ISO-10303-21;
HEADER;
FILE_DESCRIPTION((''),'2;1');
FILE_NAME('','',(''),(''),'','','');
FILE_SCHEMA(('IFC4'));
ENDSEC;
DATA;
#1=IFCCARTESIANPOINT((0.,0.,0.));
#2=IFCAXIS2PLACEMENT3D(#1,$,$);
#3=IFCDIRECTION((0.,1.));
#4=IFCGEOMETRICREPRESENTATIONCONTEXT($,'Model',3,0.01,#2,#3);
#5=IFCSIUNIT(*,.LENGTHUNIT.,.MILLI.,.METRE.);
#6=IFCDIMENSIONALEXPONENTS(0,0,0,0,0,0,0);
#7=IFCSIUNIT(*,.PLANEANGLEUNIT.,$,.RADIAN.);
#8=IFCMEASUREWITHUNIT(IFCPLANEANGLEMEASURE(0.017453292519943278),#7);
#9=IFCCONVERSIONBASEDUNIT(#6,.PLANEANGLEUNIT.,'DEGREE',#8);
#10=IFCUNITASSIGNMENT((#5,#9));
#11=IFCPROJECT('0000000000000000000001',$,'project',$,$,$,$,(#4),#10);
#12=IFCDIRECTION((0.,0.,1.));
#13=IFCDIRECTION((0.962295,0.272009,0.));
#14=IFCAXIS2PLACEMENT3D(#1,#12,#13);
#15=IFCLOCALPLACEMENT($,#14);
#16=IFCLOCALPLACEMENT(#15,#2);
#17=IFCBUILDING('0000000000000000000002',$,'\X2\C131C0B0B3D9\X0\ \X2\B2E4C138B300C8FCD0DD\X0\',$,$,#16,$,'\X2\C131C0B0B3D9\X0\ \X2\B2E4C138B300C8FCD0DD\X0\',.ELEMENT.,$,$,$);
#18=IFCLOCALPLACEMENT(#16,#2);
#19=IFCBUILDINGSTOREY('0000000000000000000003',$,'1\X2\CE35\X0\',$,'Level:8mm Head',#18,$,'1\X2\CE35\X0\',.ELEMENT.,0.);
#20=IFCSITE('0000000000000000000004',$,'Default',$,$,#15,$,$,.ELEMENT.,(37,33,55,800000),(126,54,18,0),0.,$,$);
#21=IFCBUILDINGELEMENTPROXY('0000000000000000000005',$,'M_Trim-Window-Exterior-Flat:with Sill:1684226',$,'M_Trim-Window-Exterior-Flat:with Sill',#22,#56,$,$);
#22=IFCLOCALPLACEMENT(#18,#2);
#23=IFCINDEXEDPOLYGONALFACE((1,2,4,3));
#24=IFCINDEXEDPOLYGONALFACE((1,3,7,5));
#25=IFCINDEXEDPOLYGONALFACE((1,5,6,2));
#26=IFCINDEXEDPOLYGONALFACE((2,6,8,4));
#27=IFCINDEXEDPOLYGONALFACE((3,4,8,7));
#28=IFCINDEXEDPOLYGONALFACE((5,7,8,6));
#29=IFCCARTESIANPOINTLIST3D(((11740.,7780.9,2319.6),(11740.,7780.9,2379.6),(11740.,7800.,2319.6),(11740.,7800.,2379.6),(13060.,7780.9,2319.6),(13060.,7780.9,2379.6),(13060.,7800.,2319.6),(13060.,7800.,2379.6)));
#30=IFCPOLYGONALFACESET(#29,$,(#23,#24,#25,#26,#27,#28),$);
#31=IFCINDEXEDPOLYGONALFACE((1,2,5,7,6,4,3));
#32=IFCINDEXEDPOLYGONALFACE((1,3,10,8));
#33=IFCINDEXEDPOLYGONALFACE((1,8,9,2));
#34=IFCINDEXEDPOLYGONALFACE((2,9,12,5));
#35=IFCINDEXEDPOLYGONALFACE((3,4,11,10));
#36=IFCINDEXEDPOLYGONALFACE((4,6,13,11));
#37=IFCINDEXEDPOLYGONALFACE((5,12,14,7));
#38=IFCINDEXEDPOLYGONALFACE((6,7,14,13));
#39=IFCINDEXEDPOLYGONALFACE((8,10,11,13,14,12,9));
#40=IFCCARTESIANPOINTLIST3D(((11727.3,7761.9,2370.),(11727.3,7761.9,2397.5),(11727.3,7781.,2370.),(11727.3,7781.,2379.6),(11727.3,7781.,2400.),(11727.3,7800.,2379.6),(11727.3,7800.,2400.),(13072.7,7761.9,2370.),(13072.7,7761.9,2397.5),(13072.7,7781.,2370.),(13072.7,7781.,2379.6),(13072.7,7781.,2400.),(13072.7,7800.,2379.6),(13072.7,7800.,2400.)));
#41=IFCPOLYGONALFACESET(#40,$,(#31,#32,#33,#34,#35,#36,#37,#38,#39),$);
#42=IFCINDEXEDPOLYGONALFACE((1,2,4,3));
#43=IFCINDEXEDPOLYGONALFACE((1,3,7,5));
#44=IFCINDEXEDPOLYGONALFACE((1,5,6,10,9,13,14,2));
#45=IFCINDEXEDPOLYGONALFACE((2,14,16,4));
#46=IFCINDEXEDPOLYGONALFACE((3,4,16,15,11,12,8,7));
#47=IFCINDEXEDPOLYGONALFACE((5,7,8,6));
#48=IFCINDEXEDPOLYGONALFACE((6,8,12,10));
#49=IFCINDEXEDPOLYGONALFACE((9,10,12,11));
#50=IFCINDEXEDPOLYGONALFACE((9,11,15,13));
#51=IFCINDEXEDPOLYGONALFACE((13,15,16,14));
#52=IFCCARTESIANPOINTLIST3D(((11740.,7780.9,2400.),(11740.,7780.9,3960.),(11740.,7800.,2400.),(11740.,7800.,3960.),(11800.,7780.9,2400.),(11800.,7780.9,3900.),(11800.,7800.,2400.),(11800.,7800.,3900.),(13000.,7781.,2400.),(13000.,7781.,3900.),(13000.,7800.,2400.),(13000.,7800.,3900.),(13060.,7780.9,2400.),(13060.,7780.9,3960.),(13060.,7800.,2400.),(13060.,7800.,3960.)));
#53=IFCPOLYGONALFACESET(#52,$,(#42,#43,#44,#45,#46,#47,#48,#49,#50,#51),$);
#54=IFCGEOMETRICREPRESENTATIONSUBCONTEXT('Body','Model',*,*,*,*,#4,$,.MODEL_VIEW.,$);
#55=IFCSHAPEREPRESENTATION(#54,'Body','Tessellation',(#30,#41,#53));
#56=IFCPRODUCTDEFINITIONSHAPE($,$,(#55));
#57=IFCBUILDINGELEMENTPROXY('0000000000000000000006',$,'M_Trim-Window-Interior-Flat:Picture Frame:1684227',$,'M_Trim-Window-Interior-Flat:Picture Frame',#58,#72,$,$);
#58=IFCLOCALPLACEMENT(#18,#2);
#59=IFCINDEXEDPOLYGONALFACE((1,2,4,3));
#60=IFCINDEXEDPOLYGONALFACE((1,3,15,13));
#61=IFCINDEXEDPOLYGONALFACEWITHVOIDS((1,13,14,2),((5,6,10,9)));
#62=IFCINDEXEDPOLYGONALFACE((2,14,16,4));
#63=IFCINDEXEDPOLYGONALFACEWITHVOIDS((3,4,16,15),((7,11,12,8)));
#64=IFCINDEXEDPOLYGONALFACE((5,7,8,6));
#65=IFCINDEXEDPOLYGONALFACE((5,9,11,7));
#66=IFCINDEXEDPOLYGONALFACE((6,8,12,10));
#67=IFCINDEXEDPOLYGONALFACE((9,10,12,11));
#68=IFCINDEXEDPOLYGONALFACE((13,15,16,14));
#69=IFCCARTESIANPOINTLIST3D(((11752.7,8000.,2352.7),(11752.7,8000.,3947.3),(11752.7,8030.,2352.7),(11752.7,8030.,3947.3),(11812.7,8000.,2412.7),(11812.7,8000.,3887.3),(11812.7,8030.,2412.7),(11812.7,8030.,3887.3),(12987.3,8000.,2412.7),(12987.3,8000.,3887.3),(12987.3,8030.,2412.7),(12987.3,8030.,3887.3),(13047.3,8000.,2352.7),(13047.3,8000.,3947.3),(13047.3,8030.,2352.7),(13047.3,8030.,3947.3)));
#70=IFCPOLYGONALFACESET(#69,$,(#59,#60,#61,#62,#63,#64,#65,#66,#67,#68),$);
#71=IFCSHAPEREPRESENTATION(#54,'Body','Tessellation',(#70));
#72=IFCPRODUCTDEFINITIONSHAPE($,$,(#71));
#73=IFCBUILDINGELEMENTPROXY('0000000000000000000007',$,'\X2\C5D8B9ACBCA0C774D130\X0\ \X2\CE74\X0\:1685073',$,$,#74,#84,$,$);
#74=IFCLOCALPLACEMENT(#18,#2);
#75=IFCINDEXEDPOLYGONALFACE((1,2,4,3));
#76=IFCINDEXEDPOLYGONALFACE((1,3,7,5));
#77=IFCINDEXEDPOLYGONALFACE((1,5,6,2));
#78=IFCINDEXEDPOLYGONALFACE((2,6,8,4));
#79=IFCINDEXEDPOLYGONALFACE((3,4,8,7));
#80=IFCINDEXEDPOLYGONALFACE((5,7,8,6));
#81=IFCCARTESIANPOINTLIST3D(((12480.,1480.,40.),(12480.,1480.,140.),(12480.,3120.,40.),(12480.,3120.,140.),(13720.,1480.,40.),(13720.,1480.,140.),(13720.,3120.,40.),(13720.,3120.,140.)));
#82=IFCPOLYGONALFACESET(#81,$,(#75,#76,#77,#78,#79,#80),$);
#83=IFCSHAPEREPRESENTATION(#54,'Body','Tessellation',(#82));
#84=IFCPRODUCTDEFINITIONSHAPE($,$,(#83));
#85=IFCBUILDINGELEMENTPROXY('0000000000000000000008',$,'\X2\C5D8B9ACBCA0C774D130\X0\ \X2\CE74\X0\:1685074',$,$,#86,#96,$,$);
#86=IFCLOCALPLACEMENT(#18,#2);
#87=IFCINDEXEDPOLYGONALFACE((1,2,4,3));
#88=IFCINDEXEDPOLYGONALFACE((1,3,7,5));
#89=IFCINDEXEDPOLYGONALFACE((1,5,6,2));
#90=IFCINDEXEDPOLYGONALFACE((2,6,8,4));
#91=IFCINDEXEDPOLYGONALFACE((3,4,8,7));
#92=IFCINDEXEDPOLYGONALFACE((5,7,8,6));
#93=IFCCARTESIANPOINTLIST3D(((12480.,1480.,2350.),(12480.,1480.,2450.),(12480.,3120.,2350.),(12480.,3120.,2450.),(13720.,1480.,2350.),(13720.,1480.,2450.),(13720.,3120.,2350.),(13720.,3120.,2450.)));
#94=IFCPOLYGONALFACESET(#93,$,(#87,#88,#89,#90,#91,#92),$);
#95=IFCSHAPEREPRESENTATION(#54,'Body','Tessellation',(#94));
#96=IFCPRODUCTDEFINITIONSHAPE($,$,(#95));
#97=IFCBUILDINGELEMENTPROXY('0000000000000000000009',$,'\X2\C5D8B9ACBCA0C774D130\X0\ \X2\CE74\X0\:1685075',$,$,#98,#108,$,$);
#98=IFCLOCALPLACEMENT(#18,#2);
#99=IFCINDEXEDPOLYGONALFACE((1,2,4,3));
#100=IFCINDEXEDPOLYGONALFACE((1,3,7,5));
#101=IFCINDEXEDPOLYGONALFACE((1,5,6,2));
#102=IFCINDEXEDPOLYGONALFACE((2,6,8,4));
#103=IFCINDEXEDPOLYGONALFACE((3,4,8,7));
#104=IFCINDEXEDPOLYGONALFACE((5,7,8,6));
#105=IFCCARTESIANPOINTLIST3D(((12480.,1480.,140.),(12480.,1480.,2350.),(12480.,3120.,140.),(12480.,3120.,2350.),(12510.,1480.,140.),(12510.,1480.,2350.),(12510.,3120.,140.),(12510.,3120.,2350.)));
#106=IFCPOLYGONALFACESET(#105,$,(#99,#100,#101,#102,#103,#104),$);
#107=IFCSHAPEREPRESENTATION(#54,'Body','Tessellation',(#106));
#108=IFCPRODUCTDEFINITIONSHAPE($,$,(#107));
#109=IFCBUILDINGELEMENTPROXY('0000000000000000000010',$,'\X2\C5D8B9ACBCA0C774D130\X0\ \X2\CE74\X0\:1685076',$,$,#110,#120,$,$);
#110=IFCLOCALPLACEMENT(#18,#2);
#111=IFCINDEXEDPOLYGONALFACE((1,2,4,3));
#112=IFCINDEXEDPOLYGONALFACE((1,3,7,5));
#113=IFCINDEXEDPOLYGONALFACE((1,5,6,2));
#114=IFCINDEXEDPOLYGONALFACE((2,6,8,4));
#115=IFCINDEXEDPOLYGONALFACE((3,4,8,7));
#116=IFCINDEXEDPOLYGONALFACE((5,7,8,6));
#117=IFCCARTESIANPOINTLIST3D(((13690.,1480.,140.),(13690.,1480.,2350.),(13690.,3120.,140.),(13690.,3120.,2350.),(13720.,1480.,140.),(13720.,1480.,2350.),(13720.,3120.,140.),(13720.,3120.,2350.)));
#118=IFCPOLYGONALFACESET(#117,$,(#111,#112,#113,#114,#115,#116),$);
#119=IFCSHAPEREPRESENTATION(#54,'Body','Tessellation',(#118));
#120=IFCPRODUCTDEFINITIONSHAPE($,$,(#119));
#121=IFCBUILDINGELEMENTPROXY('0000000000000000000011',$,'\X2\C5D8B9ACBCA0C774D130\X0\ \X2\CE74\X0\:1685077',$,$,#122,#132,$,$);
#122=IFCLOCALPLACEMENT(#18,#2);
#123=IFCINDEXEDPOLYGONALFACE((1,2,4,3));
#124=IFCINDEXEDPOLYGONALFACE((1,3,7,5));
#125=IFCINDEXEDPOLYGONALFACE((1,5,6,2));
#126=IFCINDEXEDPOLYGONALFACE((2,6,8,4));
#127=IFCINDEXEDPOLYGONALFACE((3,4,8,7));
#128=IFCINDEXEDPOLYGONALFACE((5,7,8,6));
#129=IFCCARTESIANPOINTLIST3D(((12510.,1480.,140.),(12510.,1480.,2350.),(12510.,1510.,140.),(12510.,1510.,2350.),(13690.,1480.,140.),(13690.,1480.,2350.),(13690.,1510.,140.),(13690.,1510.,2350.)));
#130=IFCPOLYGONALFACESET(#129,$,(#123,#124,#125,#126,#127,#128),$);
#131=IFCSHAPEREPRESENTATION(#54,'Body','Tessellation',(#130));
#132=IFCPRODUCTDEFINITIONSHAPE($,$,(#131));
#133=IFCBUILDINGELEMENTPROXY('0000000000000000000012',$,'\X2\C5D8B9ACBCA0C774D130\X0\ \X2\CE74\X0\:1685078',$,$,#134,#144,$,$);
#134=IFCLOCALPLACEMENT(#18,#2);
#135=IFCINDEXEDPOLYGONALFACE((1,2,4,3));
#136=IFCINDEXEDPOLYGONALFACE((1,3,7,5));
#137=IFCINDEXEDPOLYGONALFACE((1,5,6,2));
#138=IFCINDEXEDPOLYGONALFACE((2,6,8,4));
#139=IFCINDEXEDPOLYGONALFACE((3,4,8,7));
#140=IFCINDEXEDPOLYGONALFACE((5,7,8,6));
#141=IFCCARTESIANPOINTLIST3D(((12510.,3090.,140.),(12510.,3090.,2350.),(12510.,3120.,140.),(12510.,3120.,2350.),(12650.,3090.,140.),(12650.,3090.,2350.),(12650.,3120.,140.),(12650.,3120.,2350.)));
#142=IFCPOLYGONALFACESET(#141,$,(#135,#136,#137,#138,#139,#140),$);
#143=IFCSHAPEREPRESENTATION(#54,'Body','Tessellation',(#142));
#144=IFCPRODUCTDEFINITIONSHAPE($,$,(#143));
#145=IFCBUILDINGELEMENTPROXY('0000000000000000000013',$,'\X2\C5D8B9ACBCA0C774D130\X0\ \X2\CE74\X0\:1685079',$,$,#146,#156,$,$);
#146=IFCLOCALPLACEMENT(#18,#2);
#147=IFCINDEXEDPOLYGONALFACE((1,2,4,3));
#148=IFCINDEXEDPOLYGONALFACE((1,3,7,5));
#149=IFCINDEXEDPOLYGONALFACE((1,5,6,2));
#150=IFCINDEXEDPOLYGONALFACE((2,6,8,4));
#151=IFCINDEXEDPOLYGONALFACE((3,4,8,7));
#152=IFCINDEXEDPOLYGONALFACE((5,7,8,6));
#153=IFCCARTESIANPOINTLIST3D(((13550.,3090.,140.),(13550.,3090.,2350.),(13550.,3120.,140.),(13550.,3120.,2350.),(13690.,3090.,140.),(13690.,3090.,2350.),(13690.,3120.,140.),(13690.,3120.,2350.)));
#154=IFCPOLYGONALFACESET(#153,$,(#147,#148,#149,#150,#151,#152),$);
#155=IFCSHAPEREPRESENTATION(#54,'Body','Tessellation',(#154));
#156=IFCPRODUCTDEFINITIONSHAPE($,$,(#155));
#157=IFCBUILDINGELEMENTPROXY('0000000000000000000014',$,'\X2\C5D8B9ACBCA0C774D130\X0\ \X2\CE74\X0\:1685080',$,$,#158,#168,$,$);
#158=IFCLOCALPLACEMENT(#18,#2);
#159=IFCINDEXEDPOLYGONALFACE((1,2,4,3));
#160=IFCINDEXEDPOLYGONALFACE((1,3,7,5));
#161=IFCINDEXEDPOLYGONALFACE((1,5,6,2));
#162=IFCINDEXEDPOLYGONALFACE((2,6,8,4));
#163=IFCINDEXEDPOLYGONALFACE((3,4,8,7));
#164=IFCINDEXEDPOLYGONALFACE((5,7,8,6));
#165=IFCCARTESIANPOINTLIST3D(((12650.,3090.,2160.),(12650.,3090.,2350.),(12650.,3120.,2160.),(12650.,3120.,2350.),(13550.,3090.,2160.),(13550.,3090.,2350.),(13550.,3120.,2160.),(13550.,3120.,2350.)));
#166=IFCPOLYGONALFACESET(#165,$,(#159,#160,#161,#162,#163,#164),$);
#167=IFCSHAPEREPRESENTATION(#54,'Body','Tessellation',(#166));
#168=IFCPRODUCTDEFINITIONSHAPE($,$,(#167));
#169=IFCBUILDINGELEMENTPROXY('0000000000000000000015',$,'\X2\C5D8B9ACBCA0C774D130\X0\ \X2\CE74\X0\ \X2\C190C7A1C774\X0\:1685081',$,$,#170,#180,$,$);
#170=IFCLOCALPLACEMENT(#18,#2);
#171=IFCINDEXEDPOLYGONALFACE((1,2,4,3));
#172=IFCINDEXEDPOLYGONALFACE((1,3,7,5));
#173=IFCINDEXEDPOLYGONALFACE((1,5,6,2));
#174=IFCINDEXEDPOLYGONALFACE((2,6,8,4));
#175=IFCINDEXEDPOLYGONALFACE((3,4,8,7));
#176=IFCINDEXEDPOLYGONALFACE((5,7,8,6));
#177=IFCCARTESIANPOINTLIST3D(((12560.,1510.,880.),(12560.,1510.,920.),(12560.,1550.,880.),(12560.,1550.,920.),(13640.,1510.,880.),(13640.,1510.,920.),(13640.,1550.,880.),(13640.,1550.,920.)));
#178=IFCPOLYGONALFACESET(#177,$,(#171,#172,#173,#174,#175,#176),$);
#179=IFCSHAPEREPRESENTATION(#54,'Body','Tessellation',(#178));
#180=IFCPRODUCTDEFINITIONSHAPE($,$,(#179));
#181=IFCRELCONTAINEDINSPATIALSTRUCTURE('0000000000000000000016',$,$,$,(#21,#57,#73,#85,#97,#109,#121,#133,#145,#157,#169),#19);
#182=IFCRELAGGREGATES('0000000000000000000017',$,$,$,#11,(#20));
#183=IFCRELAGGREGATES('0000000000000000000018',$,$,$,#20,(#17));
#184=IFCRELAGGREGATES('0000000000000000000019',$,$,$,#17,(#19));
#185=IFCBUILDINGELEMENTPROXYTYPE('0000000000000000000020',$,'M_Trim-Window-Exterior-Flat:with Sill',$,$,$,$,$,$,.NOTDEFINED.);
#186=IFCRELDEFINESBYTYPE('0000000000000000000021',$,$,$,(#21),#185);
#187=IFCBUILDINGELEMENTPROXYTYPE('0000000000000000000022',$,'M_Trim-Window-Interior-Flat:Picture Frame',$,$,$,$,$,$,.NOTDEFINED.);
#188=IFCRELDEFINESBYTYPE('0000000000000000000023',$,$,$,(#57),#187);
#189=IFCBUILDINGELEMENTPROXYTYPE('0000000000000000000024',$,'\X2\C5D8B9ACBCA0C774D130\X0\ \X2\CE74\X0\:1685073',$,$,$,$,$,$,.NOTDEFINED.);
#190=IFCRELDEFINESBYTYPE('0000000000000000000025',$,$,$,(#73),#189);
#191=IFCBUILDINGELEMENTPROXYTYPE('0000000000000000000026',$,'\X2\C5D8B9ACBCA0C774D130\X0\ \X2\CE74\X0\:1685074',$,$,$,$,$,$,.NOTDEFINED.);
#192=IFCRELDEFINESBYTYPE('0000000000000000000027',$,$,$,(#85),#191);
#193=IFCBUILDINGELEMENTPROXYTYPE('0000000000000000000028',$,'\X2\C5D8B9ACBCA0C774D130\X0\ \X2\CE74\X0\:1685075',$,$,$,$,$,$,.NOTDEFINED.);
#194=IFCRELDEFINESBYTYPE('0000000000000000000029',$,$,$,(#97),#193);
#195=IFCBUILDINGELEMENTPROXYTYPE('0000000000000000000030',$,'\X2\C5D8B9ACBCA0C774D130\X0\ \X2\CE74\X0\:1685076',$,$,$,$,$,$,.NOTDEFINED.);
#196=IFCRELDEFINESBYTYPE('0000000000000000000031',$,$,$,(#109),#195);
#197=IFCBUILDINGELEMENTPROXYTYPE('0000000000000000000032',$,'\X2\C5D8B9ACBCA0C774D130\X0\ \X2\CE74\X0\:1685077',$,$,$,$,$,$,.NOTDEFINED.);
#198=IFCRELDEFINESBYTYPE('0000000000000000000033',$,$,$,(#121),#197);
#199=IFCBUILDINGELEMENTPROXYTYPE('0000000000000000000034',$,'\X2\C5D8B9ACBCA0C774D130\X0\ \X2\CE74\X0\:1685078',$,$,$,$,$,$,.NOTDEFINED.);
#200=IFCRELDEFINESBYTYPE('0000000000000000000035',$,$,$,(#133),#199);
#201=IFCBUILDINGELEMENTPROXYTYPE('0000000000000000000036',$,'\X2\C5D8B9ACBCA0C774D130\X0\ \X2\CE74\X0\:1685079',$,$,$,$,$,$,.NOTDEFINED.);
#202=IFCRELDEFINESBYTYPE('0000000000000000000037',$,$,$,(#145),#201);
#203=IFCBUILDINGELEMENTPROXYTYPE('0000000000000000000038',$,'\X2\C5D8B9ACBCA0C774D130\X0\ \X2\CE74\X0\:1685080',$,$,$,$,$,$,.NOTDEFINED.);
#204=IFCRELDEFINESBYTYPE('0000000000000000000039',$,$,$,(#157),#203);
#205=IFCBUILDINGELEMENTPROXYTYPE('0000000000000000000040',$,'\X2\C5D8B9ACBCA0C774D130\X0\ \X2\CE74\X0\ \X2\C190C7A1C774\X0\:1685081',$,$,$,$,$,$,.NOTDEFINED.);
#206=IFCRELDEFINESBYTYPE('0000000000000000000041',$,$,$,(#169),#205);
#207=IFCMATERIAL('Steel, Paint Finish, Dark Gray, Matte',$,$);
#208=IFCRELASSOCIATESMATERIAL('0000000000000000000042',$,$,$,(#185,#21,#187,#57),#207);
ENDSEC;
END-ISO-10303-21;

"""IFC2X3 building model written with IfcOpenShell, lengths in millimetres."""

from ifc_helpers import new_model, entity, si_unit, converted_unit, direction, frame, frame_2d, origin, place, context, subcontext, project, spatial, polyline, rectangle, outline, extrude, source, transform, mapped, material, type_object, type_shapes, element, save


model = new_model("IFC2X3")

# Units and contexts
model_context = context("Model", 3, precision=0.01, world=origin(), true_north=direction((0.0, 1.0)))
body_context = subcontext(model_context, "Body", "Model", "MODEL_VIEW")
ifc_project = project(units=[si_unit("LENGTHUNIT", "METRE", prefix="MILLI"), converted_unit("PLANEANGLEUNIT", "DEGREE", entity("IfcPlaneAngleMeasure", 0.017453292519943278), si_unit("PLANEANGLEUNIT", "RADIAN"), dimensions=[0, 0, 0, 0, 0, 0, 0])], contexts=[model_context])

# Site, building, storey
site_placement = place(None, frame((0.0, 0.0, 0.0), z_axis=(0.0, 0.0, 1.0), x_axis=(0.962295, 0.272009, 0.0)))
site = spatial("IfcSite", under=ifc_project, at=site_placement, Name="Default", CompositionType="ELEMENT", RefLatitude=(37, 33, 55, 800000), RefLongitude=(126, 54, 18, 0), RefElevation=0.0)
building_placement = place(site_placement, origin())
building = spatial("IfcBuilding", under=site, at=building_placement, Name="성산동 다세대주택", LongName="성산동 다세대주택", CompositionType="ELEMENT")
storey_placement = place(building_placement, origin())
storey = spatial("IfcBuildingStorey", under=building, at=storey_placement, Name="1층", ObjectType="Level:8mm Head", LongName="1층", CompositionType="ELEMENT", Elevation=0.0)

# Shared definitions
ifc_material_1 = material(Name="Steel, Paint Finish, Dark Gray, Matte")

# Building element proxies
building_element_proxy_type_1 = type_object("IfcBuildingElementProxyType", Name="M_Trim-Window-Exterior-Flat:with Sill", PredefinedType="NOTDEFINED", material=ifc_material_1)
shared_shape_1 = source(origin(), body_context, "Body", "SweptSolid", [
    extrude(rectangle(XDim=1320.0, YDim=60.0, at=frame_2d((0.0, 0.0), x_axis=(1.0, 0.0))), frame((0.0, -1550.4, 0.0), z_axis=(0.0, 0.0, 1.0), x_axis=(-1.0, 0.0, 0.0)), (0.0, 0.0, 1.0), 19.0),
    extrude(outline(polyline([(-19.0, -15.2), (0.0, -15.2), (0.0, -5.7), (19.0, -5.7), (19.0, 14.8), (0.0, 14.8), (-19.0, 12.3), (-19.0, -15.2)])), frame((-672.7, -1514.8, 19.0), z_axis=(1.0, 0.0, 0.0), x_axis=(0.0, 0.0, -1.0)), (0.0, 0.0, 1.0), 1345.4),
    extrude(outline(polyline([(-795.0, -660.0), (765.0, -660.0), (765.0, -600.0), (-735.0, -600.0), (-735.0, 600.0), (765.0, 600.0), (765.0, 660.0), (-795.0, 660.0), (-795.0, -660.0)])), frame((0.0, -735.0, 0.0), z_axis=(0.0, 0.0, 1.0), x_axis=(0.0, -1.0, 0.0)), (0.0, 0.0, 1.0), 19.0),
])
type_shapes(building_element_proxy_type_1, [shared_shape_1])
proxy_1_placement = place(storey_placement, frame((12400.0, 7800.0, 3900.0), z_axis=(0.0, -1.0, 0.0), x_axis=(1.0, 0.0, 0.0)))
element("IfcBuildingElementProxy", 1, at=proxy_1_placement, inside=storey, type_object=building_element_proxy_type_1, material=ifc_material_1, Name="M_Trim-Window-Exterior-Flat:with Sill:1684226", ObjectType="M_Trim-Window-Exterior-Flat:with Sill", context=body_context, shape_type="MappedRepresentation", body=[
    mapped(shared_shape_1, transform((0.0, 0.0, 0.0), scale=1.0)),
])
building_element_proxy_type_2 = type_object("IfcBuildingElementProxyType", Name="M_Trim-Window-Interior-Flat:Picture Frame", PredefinedType="NOTDEFINED", material=ifc_material_1)
shared_shape_2 = source(origin(), body_context, "Body", "SweptSolid", [
    extrude(outline(polyline([(-647.3, -797.3), (647.3, -797.3), (647.3, 797.3), (-647.3, 797.3), (-647.3, -797.3)]), holes=[polyline([(-587.3, -737.3), (-587.3, 737.3), (587.3, 737.3), (587.3, -737.3), (-587.3, -737.3)])]), frame((0.0, -750.0, 0.0), z_axis=(0.0, 0.0, 1.0), x_axis=(-1.0, 0.0, 0.0)), (0.0, 0.0, 1.0), 30.0),
])
type_shapes(building_element_proxy_type_2, [shared_shape_2])
proxy_2_placement = place(storey_placement, frame((12400.0, 8000.0, 3900.0), z_axis=(0.0, 1.0, 0.0), x_axis=(-1.0, 0.0, 0.0)))
element("IfcBuildingElementProxy", 2, at=proxy_2_placement, inside=storey, type_object=building_element_proxy_type_2, material=ifc_material_1, Name="M_Trim-Window-Interior-Flat:Picture Frame:1684227", ObjectType="M_Trim-Window-Interior-Flat:Picture Frame", context=body_context, shape_type="MappedRepresentation", body=[
    mapped(shared_shape_2, transform((0.0, 0.0, 0.0), scale=1.0)),
])
building_element_proxy_type_3 = type_object("IfcBuildingElementProxyType", Name="엘리베이터 카:1685073", PredefinedType="NOTDEFINED")
proxy_3_placement = place(storey_placement, origin())
element("IfcBuildingElementProxy", 3, at=proxy_3_placement, inside=storey, type_object=building_element_proxy_type_3, Name="엘리베이터 카:1685073", context=body_context, shape_type="SweptSolid", body=[
    extrude(rectangle(XDim=1240.0, YDim=1640.0, at=frame_2d((0.0, 0.0), x_axis=(1.0, 0.0))), frame((13100.0, 2300.0, 40.0)), (0.0, 0.0, 1.0), 100.0),
])
building_element_proxy_type_4 = type_object("IfcBuildingElementProxyType", Name="엘리베이터 카:1685074", PredefinedType="NOTDEFINED")
proxy_4_placement = place(storey_placement, origin())
element("IfcBuildingElementProxy", 4, at=proxy_4_placement, inside=storey, type_object=building_element_proxy_type_4, Name="엘리베이터 카:1685074", context=body_context, shape_type="SweptSolid", body=[
    extrude(rectangle(XDim=1240.0, YDim=1640.0, at=frame_2d((0.0, 0.0), x_axis=(1.0, 0.0))), frame((13100.0, 2300.0, 2350.0)), (0.0, 0.0, 1.0), 100.0),
])
building_element_proxy_type_5 = type_object("IfcBuildingElementProxyType", Name="엘리베이터 카:1685075", PredefinedType="NOTDEFINED")
proxy_5_placement = place(storey_placement, origin())
element("IfcBuildingElementProxy", 5, at=proxy_5_placement, inside=storey, type_object=building_element_proxy_type_5, Name="엘리베이터 카:1685075", context=body_context, shape_type="SweptSolid", body=[
    extrude(rectangle(XDim=30.0, YDim=1640.0, at=frame_2d((0.0, 0.0), x_axis=(1.0, 0.0))), frame((12495.0, 2300.0, 140.0)), (0.0, 0.0, 1.0), 2210.0),
])
building_element_proxy_type_6 = type_object("IfcBuildingElementProxyType", Name="엘리베이터 카:1685076", PredefinedType="NOTDEFINED")
proxy_6_placement = place(storey_placement, origin())
element("IfcBuildingElementProxy", 6, at=proxy_6_placement, inside=storey, type_object=building_element_proxy_type_6, Name="엘리베이터 카:1685076", context=body_context, shape_type="SweptSolid", body=[
    extrude(rectangle(XDim=30.0, YDim=1640.0, at=frame_2d((0.0, 0.0), x_axis=(1.0, 0.0))), frame((13705.0, 2300.0, 140.0)), (0.0, 0.0, 1.0), 2210.0),
])
building_element_proxy_type_7 = type_object("IfcBuildingElementProxyType", Name="엘리베이터 카:1685077", PredefinedType="NOTDEFINED")
proxy_7_placement = place(storey_placement, origin())
element("IfcBuildingElementProxy", 7, at=proxy_7_placement, inside=storey, type_object=building_element_proxy_type_7, Name="엘리베이터 카:1685077", context=body_context, shape_type="SweptSolid", body=[
    extrude(rectangle(XDim=1180.0, YDim=30.0, at=frame_2d((0.0, 0.0), x_axis=(1.0, 0.0))), frame((13100.0, 1495.0, 140.0)), (0.0, 0.0, 1.0), 2210.0),
])
building_element_proxy_type_8 = type_object("IfcBuildingElementProxyType", Name="엘리베이터 카:1685078", PredefinedType="NOTDEFINED")
proxy_8_placement = place(storey_placement, origin())
element("IfcBuildingElementProxy", 8, at=proxy_8_placement, inside=storey, type_object=building_element_proxy_type_8, Name="엘리베이터 카:1685078", context=body_context, shape_type="SweptSolid", body=[
    extrude(rectangle(XDim=140.0, YDim=30.0, at=frame_2d((0.0, 0.0), x_axis=(1.0, 0.0))), frame((12580.0, 3105.0, 140.0)), (0.0, 0.0, 1.0), 2210.0),
])
building_element_proxy_type_9 = type_object("IfcBuildingElementProxyType", Name="엘리베이터 카:1685079", PredefinedType="NOTDEFINED")
proxy_9_placement = place(storey_placement, origin())
element("IfcBuildingElementProxy", 9, at=proxy_9_placement, inside=storey, type_object=building_element_proxy_type_9, Name="엘리베이터 카:1685079", context=body_context, shape_type="SweptSolid", body=[
    extrude(rectangle(XDim=140.0, YDim=30.0, at=frame_2d((0.0, 0.0), x_axis=(1.0, 0.0))), frame((13620.0, 3105.0, 140.0)), (0.0, 0.0, 1.0), 2210.0),
])
building_element_proxy_type_10 = type_object("IfcBuildingElementProxyType", Name="엘리베이터 카:1685080", PredefinedType="NOTDEFINED")
proxy_10_placement = place(storey_placement, origin())
element("IfcBuildingElementProxy", 10, at=proxy_10_placement, inside=storey, type_object=building_element_proxy_type_10, Name="엘리베이터 카:1685080", context=body_context, shape_type="SweptSolid", body=[
    extrude(rectangle(XDim=900.0, YDim=30.0, at=frame_2d((0.0, 0.0), x_axis=(1.0, 0.0))), frame((13100.0, 3105.0, 2160.0)), (0.0, 0.0, 1.0), 190.0),
])
building_element_proxy_type_11 = type_object("IfcBuildingElementProxyType", Name="엘리베이터 카 손잡이:1685081", PredefinedType="NOTDEFINED")
proxy_11_placement = place(storey_placement, origin())
element("IfcBuildingElementProxy", 11, at=proxy_11_placement, inside=storey, type_object=building_element_proxy_type_11, Name="엘리베이터 카 손잡이:1685081", context=body_context, shape_type="SweptSolid", body=[
    extrude(rectangle(XDim=1080.0, YDim=40.0, at=frame_2d((0.0, 0.0), x_axis=(1.0, 0.0))), frame((13100.0, 1530.0, 880.0)), (0.0, 0.0, 1.0), 40.0),
])

save(model, "model.ifc")
